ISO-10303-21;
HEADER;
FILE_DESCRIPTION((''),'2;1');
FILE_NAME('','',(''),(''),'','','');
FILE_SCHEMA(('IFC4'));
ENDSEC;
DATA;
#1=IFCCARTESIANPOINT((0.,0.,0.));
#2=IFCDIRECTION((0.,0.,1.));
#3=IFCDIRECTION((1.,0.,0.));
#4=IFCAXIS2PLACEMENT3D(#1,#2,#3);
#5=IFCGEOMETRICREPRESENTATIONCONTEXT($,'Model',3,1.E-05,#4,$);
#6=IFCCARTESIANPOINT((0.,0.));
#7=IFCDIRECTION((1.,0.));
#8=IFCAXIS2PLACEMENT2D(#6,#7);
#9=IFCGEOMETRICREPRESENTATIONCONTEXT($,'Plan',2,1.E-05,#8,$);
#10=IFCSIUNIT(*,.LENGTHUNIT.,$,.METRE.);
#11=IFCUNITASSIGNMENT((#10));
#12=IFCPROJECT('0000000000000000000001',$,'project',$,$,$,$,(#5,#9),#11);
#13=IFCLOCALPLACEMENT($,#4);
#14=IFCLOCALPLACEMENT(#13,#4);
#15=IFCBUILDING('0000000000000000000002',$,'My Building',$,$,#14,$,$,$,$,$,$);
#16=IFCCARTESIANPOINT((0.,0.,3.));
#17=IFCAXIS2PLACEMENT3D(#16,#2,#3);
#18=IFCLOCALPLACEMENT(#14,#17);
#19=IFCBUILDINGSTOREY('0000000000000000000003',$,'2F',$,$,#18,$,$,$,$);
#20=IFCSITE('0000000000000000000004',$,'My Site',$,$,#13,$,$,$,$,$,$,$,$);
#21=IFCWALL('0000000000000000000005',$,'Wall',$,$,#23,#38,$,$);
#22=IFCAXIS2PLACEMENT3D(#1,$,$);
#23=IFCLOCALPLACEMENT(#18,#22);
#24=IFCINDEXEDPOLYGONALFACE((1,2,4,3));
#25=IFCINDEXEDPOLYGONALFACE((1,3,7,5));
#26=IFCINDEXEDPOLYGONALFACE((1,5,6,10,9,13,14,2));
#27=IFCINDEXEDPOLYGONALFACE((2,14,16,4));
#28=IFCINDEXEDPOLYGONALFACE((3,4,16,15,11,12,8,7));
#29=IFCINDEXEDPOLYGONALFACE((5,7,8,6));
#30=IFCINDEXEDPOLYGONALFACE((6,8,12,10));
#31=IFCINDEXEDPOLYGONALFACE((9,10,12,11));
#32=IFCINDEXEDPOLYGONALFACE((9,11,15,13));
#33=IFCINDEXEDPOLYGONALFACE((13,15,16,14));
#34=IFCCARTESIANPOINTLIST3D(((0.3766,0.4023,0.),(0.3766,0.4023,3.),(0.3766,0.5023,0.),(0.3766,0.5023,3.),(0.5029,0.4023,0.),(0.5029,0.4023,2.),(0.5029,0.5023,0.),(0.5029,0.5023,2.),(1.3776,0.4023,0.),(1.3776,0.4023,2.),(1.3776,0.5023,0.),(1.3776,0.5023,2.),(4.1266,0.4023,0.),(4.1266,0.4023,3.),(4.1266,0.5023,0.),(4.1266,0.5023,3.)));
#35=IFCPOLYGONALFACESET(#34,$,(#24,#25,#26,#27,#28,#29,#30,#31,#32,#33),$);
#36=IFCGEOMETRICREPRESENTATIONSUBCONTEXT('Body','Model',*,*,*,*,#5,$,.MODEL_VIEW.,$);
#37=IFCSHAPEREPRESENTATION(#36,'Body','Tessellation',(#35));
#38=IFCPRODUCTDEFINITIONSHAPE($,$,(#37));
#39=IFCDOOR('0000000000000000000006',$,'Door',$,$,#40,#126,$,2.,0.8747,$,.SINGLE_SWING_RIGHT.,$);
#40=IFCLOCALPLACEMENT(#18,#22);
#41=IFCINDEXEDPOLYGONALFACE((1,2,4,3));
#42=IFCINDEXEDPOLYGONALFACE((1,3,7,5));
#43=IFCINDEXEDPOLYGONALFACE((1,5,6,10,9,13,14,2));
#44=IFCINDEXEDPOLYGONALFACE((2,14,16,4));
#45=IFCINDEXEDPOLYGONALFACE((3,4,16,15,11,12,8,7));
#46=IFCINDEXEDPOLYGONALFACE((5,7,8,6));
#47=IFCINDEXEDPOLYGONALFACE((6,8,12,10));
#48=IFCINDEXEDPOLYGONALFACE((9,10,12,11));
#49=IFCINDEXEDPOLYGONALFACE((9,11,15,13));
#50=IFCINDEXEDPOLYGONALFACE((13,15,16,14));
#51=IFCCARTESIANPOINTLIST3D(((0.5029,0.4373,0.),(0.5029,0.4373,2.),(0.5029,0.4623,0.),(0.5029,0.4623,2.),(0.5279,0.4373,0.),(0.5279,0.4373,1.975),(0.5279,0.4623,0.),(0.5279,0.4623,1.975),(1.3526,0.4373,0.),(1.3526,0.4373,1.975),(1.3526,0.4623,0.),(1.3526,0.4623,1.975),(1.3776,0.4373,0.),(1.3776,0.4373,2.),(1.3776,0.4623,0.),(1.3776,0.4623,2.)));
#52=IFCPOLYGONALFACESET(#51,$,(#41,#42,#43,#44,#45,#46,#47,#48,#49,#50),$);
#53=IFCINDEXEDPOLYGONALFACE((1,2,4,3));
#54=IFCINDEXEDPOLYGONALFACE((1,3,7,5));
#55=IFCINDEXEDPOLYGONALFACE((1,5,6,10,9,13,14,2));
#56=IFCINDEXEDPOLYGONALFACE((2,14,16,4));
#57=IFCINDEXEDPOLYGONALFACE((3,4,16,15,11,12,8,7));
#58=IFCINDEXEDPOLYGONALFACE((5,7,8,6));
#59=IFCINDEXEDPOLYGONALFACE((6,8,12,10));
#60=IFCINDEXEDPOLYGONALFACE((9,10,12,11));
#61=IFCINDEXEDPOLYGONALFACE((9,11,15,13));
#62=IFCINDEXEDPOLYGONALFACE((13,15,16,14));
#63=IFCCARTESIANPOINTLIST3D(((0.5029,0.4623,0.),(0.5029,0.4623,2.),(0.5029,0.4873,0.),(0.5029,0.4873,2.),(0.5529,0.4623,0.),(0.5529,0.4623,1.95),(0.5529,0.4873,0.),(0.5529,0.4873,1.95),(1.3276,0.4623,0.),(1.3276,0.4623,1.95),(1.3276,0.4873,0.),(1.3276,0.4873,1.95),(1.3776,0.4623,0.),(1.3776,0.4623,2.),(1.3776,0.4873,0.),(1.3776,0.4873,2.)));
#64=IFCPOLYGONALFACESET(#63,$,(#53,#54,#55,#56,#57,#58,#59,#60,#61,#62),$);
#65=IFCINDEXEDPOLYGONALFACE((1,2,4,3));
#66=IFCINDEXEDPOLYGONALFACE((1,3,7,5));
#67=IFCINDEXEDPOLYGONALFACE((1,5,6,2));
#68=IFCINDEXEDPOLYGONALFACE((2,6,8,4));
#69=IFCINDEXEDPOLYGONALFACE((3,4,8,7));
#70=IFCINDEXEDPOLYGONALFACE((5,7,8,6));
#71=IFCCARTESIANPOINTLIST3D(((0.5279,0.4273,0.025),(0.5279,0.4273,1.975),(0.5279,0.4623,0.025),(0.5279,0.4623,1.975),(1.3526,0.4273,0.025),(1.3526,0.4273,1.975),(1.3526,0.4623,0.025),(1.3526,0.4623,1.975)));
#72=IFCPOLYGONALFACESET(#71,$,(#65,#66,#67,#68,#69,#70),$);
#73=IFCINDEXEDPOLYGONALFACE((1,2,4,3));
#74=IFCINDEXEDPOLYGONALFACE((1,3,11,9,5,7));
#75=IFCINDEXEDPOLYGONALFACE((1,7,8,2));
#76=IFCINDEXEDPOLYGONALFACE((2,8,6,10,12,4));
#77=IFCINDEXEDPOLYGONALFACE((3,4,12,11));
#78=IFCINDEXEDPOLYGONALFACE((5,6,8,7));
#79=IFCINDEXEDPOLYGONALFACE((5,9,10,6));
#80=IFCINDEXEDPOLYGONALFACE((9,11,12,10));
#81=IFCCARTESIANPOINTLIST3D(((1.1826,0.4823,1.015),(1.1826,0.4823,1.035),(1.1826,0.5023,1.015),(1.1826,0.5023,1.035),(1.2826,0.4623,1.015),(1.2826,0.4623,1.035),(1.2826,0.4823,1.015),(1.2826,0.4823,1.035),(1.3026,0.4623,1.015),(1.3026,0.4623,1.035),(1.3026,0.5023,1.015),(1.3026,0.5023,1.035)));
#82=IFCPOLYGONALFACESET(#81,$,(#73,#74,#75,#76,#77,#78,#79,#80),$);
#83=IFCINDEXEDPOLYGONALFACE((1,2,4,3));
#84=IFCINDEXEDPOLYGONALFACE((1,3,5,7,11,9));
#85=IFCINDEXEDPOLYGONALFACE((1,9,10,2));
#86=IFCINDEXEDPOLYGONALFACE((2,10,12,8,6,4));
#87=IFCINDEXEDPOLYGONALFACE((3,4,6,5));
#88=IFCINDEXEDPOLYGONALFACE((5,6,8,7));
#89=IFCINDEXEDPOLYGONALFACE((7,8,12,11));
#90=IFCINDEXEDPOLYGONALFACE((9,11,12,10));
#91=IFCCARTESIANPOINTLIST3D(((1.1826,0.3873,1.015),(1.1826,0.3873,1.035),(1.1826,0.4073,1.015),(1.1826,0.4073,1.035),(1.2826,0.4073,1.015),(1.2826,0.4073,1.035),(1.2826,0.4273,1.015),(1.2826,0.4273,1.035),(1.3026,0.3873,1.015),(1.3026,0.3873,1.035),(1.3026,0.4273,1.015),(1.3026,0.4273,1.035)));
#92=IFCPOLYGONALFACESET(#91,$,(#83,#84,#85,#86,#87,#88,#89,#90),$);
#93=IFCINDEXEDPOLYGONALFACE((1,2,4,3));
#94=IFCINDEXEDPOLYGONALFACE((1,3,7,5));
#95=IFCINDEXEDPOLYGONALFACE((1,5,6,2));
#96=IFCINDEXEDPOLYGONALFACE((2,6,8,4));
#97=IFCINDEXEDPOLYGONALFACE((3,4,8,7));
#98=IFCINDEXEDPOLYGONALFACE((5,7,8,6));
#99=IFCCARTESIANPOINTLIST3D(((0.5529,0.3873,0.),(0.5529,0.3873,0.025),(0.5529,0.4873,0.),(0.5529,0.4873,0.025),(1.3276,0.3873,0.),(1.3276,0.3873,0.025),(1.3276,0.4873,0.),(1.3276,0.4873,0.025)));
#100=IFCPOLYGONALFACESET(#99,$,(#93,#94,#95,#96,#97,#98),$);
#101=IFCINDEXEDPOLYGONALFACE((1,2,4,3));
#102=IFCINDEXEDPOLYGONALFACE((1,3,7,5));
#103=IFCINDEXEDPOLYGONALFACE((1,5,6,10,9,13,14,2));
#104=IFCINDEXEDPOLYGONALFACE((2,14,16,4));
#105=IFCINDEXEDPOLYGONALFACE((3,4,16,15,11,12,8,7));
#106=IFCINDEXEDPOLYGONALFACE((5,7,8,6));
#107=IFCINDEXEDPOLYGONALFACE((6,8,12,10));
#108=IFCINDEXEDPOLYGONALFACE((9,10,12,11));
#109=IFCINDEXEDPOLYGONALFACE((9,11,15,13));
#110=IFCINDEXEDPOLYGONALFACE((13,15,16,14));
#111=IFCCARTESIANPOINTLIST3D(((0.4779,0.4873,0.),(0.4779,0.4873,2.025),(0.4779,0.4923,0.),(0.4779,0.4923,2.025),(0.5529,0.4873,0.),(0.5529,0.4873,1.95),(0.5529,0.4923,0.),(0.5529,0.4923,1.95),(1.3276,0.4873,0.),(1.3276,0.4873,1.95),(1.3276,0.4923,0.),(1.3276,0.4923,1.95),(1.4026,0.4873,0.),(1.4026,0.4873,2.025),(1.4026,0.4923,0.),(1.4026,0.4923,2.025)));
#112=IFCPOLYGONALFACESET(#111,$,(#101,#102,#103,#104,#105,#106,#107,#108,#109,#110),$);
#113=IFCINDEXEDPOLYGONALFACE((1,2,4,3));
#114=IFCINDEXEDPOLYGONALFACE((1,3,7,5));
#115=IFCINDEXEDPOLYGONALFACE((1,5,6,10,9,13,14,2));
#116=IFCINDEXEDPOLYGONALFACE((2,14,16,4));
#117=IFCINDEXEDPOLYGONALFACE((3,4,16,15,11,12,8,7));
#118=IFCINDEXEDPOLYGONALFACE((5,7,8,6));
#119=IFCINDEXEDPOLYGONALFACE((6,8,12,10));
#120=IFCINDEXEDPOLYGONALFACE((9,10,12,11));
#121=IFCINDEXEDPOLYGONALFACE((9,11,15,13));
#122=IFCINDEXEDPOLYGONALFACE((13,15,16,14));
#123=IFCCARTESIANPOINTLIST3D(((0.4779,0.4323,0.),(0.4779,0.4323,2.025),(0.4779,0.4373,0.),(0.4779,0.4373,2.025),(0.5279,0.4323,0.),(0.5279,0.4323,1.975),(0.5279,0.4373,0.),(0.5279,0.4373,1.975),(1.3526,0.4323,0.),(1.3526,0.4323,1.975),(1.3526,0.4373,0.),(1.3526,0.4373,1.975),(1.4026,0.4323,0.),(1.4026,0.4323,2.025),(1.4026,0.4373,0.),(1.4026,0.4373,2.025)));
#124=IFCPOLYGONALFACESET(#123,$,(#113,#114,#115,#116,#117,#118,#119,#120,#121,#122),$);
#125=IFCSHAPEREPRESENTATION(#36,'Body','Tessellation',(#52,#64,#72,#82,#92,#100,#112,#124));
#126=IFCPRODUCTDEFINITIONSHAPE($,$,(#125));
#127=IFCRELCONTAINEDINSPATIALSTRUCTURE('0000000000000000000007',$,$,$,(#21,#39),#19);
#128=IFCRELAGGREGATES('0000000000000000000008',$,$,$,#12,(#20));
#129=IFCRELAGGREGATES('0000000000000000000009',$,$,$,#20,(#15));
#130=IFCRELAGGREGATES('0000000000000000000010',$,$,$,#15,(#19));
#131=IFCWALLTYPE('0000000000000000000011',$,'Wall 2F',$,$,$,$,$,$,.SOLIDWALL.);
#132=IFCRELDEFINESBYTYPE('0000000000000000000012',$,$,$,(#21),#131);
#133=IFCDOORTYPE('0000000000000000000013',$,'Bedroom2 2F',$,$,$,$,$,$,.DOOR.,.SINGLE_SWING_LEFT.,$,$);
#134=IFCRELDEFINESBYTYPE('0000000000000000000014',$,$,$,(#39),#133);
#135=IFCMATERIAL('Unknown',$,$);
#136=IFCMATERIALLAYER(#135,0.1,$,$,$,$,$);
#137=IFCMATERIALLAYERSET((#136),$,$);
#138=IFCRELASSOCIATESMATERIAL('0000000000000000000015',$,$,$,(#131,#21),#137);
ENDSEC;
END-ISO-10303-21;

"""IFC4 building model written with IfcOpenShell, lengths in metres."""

from ifc_helpers import new_model, entity, si_unit, frame, origin_with_axes, origin_2d_with_axis, place, context, subcontext, project, spatial, line, indexed_curve, outline, extrude, shape, source, transform, mapped, material, layer, layer_set, layer_usage, type_object, type_shapes, element, fill, save


model = new_model("IFC4")

# Units and contexts
model_context = context("Model", 3, precision=1e-05, world=origin_with_axes())
plan_context = context("Plan", 2, precision=1e-05, world=origin_2d_with_axis())
body_context_1 = subcontext(model_context, "Body", "Model", "MODEL_VIEW")
body_context_2 = subcontext(plan_context, "Body", "Plan", "PLAN_VIEW")
ifc_project = project(units=[si_unit("LENGTHUNIT", "METRE")], contexts=[model_context, plan_context])

# Site, building, storey
site_placement = place(None, origin_with_axes())
site = spatial("IfcSite", under=ifc_project, at=site_placement, Name="My Site")
building_placement = place(site_placement, origin_with_axes())
building = spatial("IfcBuilding", under=site, at=building_placement, Name="My Building")
storey_placement = place(building_placement, frame((0.0, 0.0, 3.0), z_axis=(0.0, 0.0, 1.0), x_axis=(1.0, 0.0, 0.0)))
storey = spatial("IfcBuildingStorey", under=building, at=storey_placement, Name="2F")

# Shared definitions
ifc_material = material(Name="Unknown")

# Shared definitions
ifc_layer_1 = layer(ifc_material, 0.1)
ifc_layer_set_1 = layer_set([ifc_layer_1])
wall_type = type_object("IfcWallType", Name="Wall 2F", PredefinedType="SOLIDWALL", material=ifc_layer_set_1)

# Wall, opening, door
ifc_layer_usage_1 = layer_usage(ifc_layer_set_1, "AXIS2", "POSITIVE", 0.0)
wall_1_placement = place(storey_placement, frame((4.2266, 0.5023, 0.0), z_axis=(0.0, 0.0, 1.0), x_axis=(-1.0, 0.0, 0.0)))
wall_1 = element("IfcWall", 1, at=wall_1_placement, inside=storey, type_object=wall_type, material=ifc_layer_usage_1, Name="Wall", context=body_context_1, shape_type="SweptSolid", body=[
    extrude(outline(indexed_curve([(0.1, 0.0), (0.1, 0.1), (3.85, 0.1), (3.85, 0.0)], segments=[line(1, 2, 3, 4, 1)])), origin_with_axes(), (0.0, 0.0, 1.0), 3.0),
])
shared_shape_1 = source(origin_with_axes(), body_context_1, "Body", "SweptSolid", [
    extrude(outline(indexed_curve([(0.0, 0.0), (0.8747, 0.0), (0.8747, 2.0), (0.0, 2.0)], segments=[line(1, 2, 3, 4, 1)])), frame((0.0, -0.6, 0.0), z_axis=(0.0, -1.0, 0.0), x_axis=(1.0, 0.0, 0.0)), (0.0, 0.0, -1.0), 1.2),
])
opening_1_placement = place(wall_1_placement, frame((2.849, 0.015, 0.0), z_axis=(0.0, 0.0, 1.0), x_axis=(1.0, -0.000001, 0.0)))
opening_1 = element("IfcOpeningElement", 2, at=opening_1_placement, cuts=wall_1, PredefinedType="OPENING", context=body_context_1, shape_type="MappedRepresentation", body=[
    mapped(shared_shape_1, transform((0.0, 0.0, 0.0), x_axis=(1.0, 0.0, 0.0), y_axis=(0.0, 1.0, 0.0), z_axis=(0.0, 0.0, 1.0), scale=1.0)),
])
door_type_1 = type_object("IfcDoorType", Name="Bedroom2 2F", OperationType="SINGLE_SWING_LEFT", PredefinedType="DOOR")
shared_shape_2 = source(origin_with_axes(), body_context_1, "Body", "SweptSolid", [
    extrude(outline(indexed_curve([(0.0, 0.0), (0.0, 2.0), (0.8747, 2.0), (0.8747, 0.0), (0.8497, 0.0), (0.8497, 1.975), (0.025, 1.975), (0.025, 0.0)], segments=[line(1, 2, 3, 4, 5, 6, 7, 8, 1)])), frame((0.0, 0.025, 0.0), z_axis=(0.0, -1.0, 0.0), x_axis=(1.0, 0.0, 0.0)), (0.0, 0.0, -1.0), 0.025),
    extrude(outline(indexed_curve([(0.0, 0.0), (0.0, 2.0), (0.8747, 2.0), (0.8747, 0.0), (0.8247, 0.0), (0.8247, 1.95), (0.05, 1.95), (0.05, 0.0)], segments=[line(1, 2, 3, 4, 5, 6, 7, 8, 1)])), frame((0.0, 0.0, 0.0), z_axis=(0.0, -1.0, 0.0), x_axis=(1.0, 0.0, 0.0)), (0.0, 0.0, -1.0), 0.025),
    extrude(outline(indexed_curve([(0.0, 0.0), (0.8247, 0.0), (0.8247, 0.035), (0.0, 0.035)], segments=[line(1, 2, 3, 4, 1)])), frame((0.025, 0.025, 0.025), z_axis=(0.0, 0.0, 1.0), x_axis=(1.0, 0.0, 0.0)), (0.0, 0.0, 1.0), 1.95),
    extrude(outline(indexed_curve([(0.0, 0.0), (0.0, -0.04), (0.12, -0.04), (0.12, -0.02), (0.02, -0.02), (0.02, 0.0)], segments=[line(1, 2, 3, 4, 5, 6, 1)])), frame((0.075, 0.025, 1.015), z_axis=(0.0, 0.0, 1.0), x_axis=(1.0, 0.0, 0.0)), (0.0, 0.0, 1.0), 0.02),
    extrude(outline(indexed_curve([(0.0, 0.0), (0.0, 0.04), (0.12, 0.04), (0.12, 0.02), (0.02, 0.02), (0.02, 0.0)], segments=[line(1, 2, 3, 4, 5, 6, 1)])), frame((0.075, 0.06, 1.015), z_axis=(0.0, 0.0, 1.0), x_axis=(1.0, 0.0, 0.0)), (0.0, 0.0, 1.0), 0.02),
    extrude(outline(indexed_curve([(0.0, 0.0), (0.7747, 0.0), (0.7747, 0.1), (0.0, 0.1)], segments=[line(1, 2, 3, 4, 1)])), frame((0.05, 0.0, 0.0), z_axis=(0.0, 0.0, 1.0), x_axis=(1.0, 0.0, 0.0)), (0.0, 0.0, 1.0), 0.025),
    extrude(outline(indexed_curve([(0.0, 0.0), (0.0, 2.025), (0.9247, 2.025), (0.9247, 0.0), (0.8497, 0.0), (0.8497, 1.95), (0.075, 1.95), (0.075, 0.0)], segments=[line(1, 2, 3, 4, 5, 6, 7, 8, 1)])), frame((-0.025, -0.005, 0.0), z_axis=(0.0, -1.0, 0.0), x_axis=(1.0, 0.0, 0.0)), (0.0, 0.0, -1.0), 0.005),
    extrude(outline(indexed_curve([(0.0, 0.0), (0.0, 2.025), (0.9247, 2.025), (0.9247, 0.0), (0.8747, 0.0), (0.8747, 1.975), (0.05, 1.975), (0.05, 0.0)], segments=[line(1, 2, 3, 4, 5, 6, 7, 8, 1)])), frame((-0.025, 0.05, 0.0), z_axis=(0.0, -1.0, 0.0), x_axis=(1.0, 0.0, 0.0)), (0.0, 0.0, -1.0), 0.005),
])
shared_shape_3 = source(origin_with_axes(), body_context_2, "Body", "Curve2D", [
    entity("IfcIndexedPolyCurve", entity("IfcCartesianPointList2D", [[0.0, 0.0], [0.0, 0.05], [0.025, 0.05], [0.025, 0.025], [0.05, 0.025], [0.05, 0.0]]), [entity("IfcLineIndex", [1, 2, 3, 4, 5, 6, 1])]),
    entity("IfcIndexedPolyCurve", entity("IfcCartesianPointList2D", [[0.8747, 0.0], [0.8747, 0.05], [0.8497, 0.05], [0.8497, 0.025], [0.8247, 0.025], [0.8247, 0.0]]), [entity("IfcLineIndex", [1, 2, 3, 4, 5, 6, 1])]),
    entity("IfcTrimmedCurve", entity("IfcEllipse", entity("IfcAxis2Placement2D", entity("IfcCartesianPoint", [0.8147, 0.05]), entity("IfcDirection", [1.0, 0.0])), 0.7897, 0.8247), [entity("IfcCartesianPoint", [0.8147, 0.8747])], [entity("IfcCartesianPoint", [0.025, 0.05])], True, "CARTESIAN"),
    entity("IfcIndexedPolyCurve", entity("IfcCartesianPointList2D", [[0.8497, 0.05], [0.8147, 0.05], [0.8147, 0.8747], [0.8497, 0.8747]]), [entity("IfcLineIndex", [1, 2, 3, 4, 1])]),
])
type_shapes(door_type_1, [shared_shape_2, shared_shape_3])
door_1_placement = place(opening_1_placement, frame((0.0, 0.0, 0.0), z_axis=(0.0, 0.0, 1.0), x_axis=(1.0, 0.0, 0.0)))
door_1 = element("IfcDoor", 3, at=door_1_placement, inside=storey, type_object=door_type_1, Name="Door", OperationType="SINGLE_SWING_RIGHT", OverallHeight=2.0, OverallWidth=0.8747, shapes=[
    shape(body_context_1, "Body", "MappedRepresentation", [mapped(shared_shape_2, transform((0.0, 0.0, 0.0), x_axis=(1.0, 0.0, 0.0), y_axis=(0.0, 1.0, 0.0), z_axis=(0.0, 0.0, 1.0), scale=1.0))]),
    shape(body_context_2, "Body", "MappedRepresentation", [mapped(shared_shape_3, transform((0.0, 0.0, 0.0), x_axis=(1.0, 0.0, 0.0), y_axis=(0.0, 1.0, 0.0), z_axis=(0.0, 0.0, 1.0), scale=1.0))]),
])
fill(opening_1, door_1)

save(model, "model.ifc")
